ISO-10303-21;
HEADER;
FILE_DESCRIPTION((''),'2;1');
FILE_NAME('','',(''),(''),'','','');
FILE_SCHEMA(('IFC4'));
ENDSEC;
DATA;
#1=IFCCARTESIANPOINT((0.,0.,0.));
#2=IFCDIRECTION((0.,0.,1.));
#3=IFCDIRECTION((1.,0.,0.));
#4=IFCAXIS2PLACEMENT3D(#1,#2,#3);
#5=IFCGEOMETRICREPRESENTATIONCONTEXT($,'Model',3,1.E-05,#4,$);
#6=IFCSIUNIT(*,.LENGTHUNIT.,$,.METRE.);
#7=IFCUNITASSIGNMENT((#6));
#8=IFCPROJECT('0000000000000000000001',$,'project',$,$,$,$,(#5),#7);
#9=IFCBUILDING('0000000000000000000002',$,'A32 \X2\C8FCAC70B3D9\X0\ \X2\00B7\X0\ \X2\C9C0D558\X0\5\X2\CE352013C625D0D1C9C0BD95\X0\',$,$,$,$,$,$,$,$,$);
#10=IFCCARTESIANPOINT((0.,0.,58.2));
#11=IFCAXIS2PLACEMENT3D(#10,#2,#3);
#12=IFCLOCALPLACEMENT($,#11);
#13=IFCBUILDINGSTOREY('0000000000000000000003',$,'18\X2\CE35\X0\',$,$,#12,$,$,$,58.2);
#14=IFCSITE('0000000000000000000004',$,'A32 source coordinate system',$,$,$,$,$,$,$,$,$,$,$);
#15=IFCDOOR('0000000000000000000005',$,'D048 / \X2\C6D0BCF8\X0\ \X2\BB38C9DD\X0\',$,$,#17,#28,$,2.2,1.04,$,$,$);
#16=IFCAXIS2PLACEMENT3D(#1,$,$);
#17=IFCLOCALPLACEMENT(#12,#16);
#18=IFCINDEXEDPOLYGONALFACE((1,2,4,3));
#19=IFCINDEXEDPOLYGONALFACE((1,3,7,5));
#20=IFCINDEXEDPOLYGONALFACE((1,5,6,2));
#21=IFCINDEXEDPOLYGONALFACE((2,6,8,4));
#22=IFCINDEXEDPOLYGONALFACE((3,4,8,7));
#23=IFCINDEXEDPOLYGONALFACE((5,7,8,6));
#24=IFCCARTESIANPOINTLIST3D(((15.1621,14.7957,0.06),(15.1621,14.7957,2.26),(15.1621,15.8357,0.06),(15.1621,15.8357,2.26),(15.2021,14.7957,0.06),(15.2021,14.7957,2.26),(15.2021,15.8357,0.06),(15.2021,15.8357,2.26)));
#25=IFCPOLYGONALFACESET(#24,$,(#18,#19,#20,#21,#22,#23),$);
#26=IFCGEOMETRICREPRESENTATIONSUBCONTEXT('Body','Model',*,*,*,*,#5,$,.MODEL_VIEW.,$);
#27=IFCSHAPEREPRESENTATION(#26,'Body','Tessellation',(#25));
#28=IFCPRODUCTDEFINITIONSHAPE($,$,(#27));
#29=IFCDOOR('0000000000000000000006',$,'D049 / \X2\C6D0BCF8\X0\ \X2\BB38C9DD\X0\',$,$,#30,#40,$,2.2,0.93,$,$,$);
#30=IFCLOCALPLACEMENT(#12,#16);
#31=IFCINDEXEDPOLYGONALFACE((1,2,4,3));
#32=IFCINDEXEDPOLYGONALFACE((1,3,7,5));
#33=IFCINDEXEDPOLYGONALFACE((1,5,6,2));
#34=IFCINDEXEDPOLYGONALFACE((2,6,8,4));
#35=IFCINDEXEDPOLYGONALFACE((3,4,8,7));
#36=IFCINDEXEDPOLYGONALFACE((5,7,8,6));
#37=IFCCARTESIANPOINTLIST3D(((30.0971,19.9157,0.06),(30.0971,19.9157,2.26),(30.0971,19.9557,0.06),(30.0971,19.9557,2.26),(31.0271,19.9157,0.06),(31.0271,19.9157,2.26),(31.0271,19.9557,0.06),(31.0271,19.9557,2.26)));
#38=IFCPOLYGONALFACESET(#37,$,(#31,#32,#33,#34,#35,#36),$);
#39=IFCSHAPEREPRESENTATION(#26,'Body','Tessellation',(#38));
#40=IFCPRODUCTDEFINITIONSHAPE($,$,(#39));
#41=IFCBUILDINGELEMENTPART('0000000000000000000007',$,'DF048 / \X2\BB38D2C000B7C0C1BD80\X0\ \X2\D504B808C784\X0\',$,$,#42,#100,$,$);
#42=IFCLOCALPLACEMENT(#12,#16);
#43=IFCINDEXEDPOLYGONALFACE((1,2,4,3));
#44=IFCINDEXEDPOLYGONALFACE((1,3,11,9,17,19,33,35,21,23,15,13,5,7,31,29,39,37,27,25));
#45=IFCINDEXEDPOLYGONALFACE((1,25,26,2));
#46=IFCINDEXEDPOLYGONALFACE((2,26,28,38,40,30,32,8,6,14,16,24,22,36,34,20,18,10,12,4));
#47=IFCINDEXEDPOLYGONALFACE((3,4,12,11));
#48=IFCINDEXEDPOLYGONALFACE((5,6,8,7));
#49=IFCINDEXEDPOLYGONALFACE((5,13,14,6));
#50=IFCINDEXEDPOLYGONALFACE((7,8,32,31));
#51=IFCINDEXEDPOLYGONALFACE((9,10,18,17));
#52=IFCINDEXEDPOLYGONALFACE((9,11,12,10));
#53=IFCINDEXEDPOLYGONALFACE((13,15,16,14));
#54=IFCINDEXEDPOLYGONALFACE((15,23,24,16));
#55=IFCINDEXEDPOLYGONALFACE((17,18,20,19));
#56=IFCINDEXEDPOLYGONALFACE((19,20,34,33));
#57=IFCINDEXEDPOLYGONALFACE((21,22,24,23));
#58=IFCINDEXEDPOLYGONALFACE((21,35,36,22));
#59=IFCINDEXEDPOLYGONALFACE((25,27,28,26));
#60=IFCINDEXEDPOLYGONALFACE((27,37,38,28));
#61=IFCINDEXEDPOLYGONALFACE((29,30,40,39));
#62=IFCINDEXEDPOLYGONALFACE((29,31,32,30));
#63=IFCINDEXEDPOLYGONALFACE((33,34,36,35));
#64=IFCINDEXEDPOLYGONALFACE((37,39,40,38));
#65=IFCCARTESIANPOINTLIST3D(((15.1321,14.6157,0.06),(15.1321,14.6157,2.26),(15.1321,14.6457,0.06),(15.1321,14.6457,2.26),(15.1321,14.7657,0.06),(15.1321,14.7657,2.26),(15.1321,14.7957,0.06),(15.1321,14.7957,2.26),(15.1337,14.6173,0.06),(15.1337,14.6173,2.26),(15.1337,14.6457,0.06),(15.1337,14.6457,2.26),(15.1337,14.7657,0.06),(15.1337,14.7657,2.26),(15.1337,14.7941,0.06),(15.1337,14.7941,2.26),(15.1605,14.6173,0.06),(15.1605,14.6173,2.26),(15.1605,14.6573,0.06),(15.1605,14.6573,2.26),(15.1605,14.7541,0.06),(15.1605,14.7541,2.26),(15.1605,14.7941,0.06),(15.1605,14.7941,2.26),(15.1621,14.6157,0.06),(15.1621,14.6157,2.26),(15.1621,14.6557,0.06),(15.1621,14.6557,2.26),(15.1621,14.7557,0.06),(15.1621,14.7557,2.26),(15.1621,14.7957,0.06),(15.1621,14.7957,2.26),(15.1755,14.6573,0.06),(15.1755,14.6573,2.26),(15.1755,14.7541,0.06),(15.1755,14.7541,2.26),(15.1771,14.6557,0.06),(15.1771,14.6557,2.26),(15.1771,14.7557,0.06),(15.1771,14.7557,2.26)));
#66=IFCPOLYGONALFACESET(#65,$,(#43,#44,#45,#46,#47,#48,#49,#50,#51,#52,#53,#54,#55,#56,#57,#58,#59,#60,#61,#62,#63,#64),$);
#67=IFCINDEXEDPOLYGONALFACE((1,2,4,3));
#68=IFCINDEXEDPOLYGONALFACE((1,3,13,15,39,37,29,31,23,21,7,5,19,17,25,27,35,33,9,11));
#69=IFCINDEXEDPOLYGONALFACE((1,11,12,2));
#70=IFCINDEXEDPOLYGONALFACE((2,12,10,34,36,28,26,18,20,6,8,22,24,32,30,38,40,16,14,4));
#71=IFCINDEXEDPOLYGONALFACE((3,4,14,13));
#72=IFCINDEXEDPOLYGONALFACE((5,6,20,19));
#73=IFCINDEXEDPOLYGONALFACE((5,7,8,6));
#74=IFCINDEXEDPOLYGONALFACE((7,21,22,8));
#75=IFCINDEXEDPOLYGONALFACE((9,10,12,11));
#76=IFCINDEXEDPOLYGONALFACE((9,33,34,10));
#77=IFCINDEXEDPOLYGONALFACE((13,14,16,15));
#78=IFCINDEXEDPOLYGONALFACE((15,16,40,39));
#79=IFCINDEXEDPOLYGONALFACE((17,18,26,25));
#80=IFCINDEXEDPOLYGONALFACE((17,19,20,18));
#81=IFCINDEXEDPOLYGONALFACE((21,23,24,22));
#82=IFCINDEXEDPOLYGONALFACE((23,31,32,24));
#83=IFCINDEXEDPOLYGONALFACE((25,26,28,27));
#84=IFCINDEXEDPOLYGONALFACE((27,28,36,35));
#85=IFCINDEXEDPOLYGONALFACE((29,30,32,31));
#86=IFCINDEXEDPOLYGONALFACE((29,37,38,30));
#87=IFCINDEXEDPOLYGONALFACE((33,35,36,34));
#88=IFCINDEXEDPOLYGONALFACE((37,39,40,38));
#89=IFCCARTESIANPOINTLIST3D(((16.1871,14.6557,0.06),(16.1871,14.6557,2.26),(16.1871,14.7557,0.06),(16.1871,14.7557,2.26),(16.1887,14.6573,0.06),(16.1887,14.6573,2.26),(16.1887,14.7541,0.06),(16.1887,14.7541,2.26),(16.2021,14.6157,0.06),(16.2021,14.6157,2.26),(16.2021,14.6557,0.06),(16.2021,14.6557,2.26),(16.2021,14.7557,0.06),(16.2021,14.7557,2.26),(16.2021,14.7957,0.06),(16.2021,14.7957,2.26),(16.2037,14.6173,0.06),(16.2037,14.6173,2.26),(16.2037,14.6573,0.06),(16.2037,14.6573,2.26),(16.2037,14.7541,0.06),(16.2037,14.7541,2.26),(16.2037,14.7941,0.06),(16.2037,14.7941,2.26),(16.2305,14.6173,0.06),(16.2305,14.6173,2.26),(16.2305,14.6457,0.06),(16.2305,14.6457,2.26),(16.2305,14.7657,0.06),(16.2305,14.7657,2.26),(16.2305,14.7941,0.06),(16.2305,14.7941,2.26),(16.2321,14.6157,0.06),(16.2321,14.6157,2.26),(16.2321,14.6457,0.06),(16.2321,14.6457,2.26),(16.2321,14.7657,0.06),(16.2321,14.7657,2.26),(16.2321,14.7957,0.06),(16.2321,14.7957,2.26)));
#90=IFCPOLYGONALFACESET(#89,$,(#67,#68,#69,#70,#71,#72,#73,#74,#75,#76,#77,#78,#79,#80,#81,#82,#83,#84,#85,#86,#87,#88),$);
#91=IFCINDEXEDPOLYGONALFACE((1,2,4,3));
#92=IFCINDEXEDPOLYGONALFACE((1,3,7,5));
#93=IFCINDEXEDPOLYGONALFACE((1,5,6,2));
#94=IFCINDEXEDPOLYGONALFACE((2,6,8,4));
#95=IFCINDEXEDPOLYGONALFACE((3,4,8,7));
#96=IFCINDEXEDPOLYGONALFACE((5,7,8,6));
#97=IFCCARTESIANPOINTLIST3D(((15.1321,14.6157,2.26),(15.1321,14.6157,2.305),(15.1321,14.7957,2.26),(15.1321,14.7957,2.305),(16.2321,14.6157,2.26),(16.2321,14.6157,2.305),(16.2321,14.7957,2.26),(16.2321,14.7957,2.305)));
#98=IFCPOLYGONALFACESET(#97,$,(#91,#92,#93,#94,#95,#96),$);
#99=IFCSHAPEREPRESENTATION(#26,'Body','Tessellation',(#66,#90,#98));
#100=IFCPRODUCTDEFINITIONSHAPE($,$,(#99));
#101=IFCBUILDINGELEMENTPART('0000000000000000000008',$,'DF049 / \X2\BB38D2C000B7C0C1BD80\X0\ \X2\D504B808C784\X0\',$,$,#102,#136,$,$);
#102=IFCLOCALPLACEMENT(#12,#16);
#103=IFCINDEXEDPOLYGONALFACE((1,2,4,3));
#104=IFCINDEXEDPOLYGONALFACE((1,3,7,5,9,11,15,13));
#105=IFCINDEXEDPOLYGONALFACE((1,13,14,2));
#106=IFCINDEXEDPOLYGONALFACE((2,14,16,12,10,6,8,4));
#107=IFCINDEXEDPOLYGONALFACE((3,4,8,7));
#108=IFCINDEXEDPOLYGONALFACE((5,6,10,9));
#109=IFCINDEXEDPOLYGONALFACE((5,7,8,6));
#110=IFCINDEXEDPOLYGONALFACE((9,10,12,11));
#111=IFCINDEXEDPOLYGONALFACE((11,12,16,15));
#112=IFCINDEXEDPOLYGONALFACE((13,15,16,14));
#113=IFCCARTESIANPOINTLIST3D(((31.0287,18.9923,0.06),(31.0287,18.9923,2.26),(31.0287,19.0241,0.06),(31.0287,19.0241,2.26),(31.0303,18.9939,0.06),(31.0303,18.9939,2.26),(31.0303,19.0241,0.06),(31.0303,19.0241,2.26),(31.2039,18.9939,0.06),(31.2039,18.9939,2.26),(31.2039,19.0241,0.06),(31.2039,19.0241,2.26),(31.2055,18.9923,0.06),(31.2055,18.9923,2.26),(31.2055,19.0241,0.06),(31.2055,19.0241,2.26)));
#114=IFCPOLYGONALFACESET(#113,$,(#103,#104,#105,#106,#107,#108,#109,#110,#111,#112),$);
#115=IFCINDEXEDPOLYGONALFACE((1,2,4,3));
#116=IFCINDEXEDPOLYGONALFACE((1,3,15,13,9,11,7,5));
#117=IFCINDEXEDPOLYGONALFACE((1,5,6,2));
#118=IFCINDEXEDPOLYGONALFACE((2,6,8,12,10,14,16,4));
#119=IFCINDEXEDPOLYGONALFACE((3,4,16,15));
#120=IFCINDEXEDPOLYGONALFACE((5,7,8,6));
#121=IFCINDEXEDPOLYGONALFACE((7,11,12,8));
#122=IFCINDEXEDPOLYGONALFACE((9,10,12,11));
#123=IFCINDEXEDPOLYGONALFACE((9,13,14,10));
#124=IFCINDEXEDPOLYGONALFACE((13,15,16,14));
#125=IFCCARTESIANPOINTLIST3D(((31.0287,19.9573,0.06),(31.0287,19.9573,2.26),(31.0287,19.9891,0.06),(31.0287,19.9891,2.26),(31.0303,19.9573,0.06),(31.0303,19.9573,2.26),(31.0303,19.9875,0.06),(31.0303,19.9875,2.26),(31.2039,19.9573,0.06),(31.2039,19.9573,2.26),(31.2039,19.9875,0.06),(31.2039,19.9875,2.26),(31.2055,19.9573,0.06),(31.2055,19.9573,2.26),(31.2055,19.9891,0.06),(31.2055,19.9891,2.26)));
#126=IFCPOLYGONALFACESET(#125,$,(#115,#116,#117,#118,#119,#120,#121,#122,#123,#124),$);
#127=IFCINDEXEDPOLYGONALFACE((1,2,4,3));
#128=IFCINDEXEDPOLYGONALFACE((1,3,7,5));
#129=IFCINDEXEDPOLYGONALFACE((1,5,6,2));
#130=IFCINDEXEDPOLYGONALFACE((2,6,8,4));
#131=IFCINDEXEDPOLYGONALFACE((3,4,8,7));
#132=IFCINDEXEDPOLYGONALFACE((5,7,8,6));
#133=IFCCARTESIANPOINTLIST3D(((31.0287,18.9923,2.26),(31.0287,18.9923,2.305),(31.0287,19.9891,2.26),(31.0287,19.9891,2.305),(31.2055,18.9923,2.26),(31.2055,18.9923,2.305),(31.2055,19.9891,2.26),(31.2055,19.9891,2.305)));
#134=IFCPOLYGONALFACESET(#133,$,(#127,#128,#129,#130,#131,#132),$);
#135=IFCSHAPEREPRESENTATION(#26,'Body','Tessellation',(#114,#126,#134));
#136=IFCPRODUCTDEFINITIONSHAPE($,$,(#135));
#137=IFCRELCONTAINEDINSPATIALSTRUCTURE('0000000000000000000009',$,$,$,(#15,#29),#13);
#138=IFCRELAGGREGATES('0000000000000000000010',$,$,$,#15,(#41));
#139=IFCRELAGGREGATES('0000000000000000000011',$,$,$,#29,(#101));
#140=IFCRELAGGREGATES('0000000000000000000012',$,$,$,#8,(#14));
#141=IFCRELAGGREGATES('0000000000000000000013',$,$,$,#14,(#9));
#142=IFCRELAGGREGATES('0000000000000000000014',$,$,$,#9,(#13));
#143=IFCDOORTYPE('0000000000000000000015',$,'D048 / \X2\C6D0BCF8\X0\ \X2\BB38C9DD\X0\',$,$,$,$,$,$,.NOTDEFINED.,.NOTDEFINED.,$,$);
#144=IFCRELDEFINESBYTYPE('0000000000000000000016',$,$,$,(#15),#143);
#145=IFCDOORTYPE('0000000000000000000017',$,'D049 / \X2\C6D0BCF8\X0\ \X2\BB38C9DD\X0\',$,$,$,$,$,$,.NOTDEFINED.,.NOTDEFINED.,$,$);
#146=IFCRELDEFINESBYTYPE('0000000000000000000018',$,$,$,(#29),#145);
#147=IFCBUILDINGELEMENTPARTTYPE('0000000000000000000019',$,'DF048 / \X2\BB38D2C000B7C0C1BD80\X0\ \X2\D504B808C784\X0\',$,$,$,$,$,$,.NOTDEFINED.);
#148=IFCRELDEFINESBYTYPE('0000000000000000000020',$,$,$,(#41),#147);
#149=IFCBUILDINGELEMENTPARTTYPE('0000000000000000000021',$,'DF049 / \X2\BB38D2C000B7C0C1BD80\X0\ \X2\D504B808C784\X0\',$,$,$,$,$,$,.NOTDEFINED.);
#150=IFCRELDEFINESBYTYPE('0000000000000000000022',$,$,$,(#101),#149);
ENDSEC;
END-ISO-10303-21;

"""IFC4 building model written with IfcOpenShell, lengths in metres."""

from ifc_helpers import new_model, si_unit, frame, origin, origin_with_axes, place, context, subcontext, project, spatial, polyline, outline, extrude, source, transform, mapped, type_object, type_shapes, element, aggregate, save


model = new_model("IFC4")

# Units and contexts
model_context = context("Model", 3, precision=1e-05, world=origin_with_axes())
body_context = subcontext(model_context, "Body", "Model", "MODEL_VIEW")
ifc_project = project(units=[si_unit("LENGTHUNIT", "METRE")], contexts=[model_context])

# Site, building, storey
storey_placement = place(None, frame((0.0, 0.0, 58.2), z_axis=(0.0, 0.0, 1.0), x_axis=(1.0, 0.0, 0.0)))
site = spatial("IfcSite", under=ifc_project, Name="A32 source coordinate system")
building = spatial("IfcBuilding", under=site, Name="A32 주거동 · 지하5층–옥탑지붕")
storey = spatial("IfcBuildingStorey", under=building, at=storey_placement, Name="18층", Elevation=58.2)

# Doors
door_type_1 = type_object("IfcDoorType", Name="D048 / 원본 문짝", OperationType="NOTDEFINED", PredefinedType="NOTDEFINED")
shared_shape_1 = source(origin(), body_context, "Body", "SweptSolid", [
    extrude(outline(polyline([(15.2021, 15.8357), (15.2021, 14.7957), (15.1621, 14.7957), (15.1621, 15.8357), (15.2021, 15.8357)])), frame((0.0, 0.0, 0.06)), (0.0, 0.0, 1.0), 2.2),
])
type_shapes(door_type_1, [shared_shape_1])
door_1_placement = place(storey_placement, origin_with_axes())
door_1 = element("IfcDoor", 1, at=door_1_placement, inside=storey, type_object=door_type_1, Name="D048 / 원본 문짝", OverallHeight=2.2, OverallWidth=1.04, context=body_context, shape_type="MappedRepresentation", body=[
    mapped(shared_shape_1, transform((0.0, 0.0, 0.0), scale=1.0)),
])
door_type_2 = type_object("IfcDoorType", Name="D049 / 원본 문짝", OperationType="NOTDEFINED", PredefinedType="NOTDEFINED")
shared_shape_2 = source(origin(), body_context, "Body", "SweptSolid", [
    extrude(outline(polyline([(31.0271, 19.9557), (31.0271, 19.9157), (30.0971, 19.9157), (30.0971, 19.9557), (31.0271, 19.9557)])), frame((0.0, 0.0, 0.06)), (0.0, 0.0, 1.0), 2.2),
])
type_shapes(door_type_2, [shared_shape_2])
door_2_placement = place(storey_placement, origin_with_axes())
door_2 = element("IfcDoor", 2, at=door_2_placement, inside=storey, type_object=door_type_2, Name="D049 / 원본 문짝", OverallHeight=2.2, OverallWidth=0.93, context=body_context, shape_type="MappedRepresentation", body=[
    mapped(shared_shape_2, transform((0.0, 0.0, 0.0), scale=1.0)),
])

# Building element parts
building_element_part_type_1 = type_object("IfcBuildingElementPartType", Name="DF048 / 문틀·상부 프레임", PredefinedType="NOTDEFINED")
shared_shape_3 = source(origin(), body_context, "Body", "SweptSolid", [
    extrude(outline(polyline([(15.1321, 14.7657), (15.1321, 14.7957), (15.1621, 14.7957), (15.1621, 14.7557), (15.1771, 14.7557), (15.1771, 14.6557), (15.1621, 14.6557), (15.1621, 14.6157), (15.1321, 14.6157), (15.1321, 14.6457), (15.1337, 14.6457), (15.1337, 14.6173), (15.1605, 14.6173), (15.1605, 14.6573), (15.1755, 14.6573), (15.1755, 14.7541), (15.1605, 14.7541), (15.1605, 14.7941), (15.1337, 14.7941), (15.1337, 14.7657), (15.1321, 14.7657)])), frame((0.0, 0.0, 0.06)), (0.0, 0.0, 1.0), 2.2),
    extrude(outline(polyline([(16.2305, 14.7941), (16.2037, 14.7941), (16.2037, 14.7541), (16.1887, 14.7541), (16.1887, 14.6573), (16.2037, 14.6573), (16.2037, 14.6173), (16.2305, 14.6173), (16.2305, 14.6457), (16.2321, 14.6457), (16.2321, 14.6157), (16.2021, 14.6157), (16.2021, 14.6557), (16.1871, 14.6557), (16.1871, 14.7557), (16.2021, 14.7557), (16.2021, 14.7957), (16.2321, 14.7957), (16.2321, 14.7657), (16.2305, 14.7657), (16.2305, 14.7941)])), frame((0.0, 0.0, 0.06)), (0.0, 0.0, 1.0), 2.2),
    extrude(outline(polyline([(15.1321, 14.6157), (15.1321, 14.7957), (16.2321, 14.7957), (16.2321, 14.6157), (15.1321, 14.6157)])), frame((0.0, 0.0, 2.26)), (0.0, 0.0, 1.0), 0.045),
])
type_shapes(building_element_part_type_1, [shared_shape_3])
building_element_part_1_placement = place(door_1_placement, origin_with_axes())
building_element_part_1 = element("IfcBuildingElementPart", 3, at=building_element_part_1_placement, type_object=building_element_part_type_1, Name="DF048 / 문틀·상부 프레임", context=body_context, shape_type="MappedRepresentation", body=[
    mapped(shared_shape_3, transform((0.0, 0.0, 0.0), scale=1.0)),
])
aggregate(door_1, [building_element_part_1])
building_element_part_type_2 = type_object("IfcBuildingElementPartType", Name="DF049 / 문틀·상부 프레임", PredefinedType="NOTDEFINED")
shared_shape_4 = source(origin(), body_context, "Body", "SweptSolid", [
    extrude(outline(polyline([(31.0303, 19.0241), (31.0303, 18.9939), (31.2039, 18.9939), (31.2039, 19.0241), (31.2055, 19.0241), (31.2055, 18.9923), (31.0287, 18.9923), (31.0287, 19.0241), (31.0303, 19.0241)])), frame((0.0, 0.0, 0.06)), (0.0, 0.0, 1.0), 2.2),
    extrude(outline(polyline([(31.0287, 19.9891), (31.2055, 19.9891), (31.2055, 19.9573), (31.2039, 19.9573), (31.2039, 19.9875), (31.0303, 19.9875), (31.0303, 19.9573), (31.0287, 19.9573), (31.0287, 19.9891)])), frame((0.0, 0.0, 0.06)), (0.0, 0.0, 1.0), 2.2),
    extrude(outline(polyline([(31.0287, 18.9923), (31.0287, 19.9891), (31.2055, 19.9891), (31.2055, 18.9923), (31.0287, 18.9923)])), frame((0.0, 0.0, 2.26)), (0.0, 0.0, 1.0), 0.045),
])
type_shapes(building_element_part_type_2, [shared_shape_4])
building_element_part_2_placement = place(door_2_placement, origin_with_axes())
building_element_part_2 = element("IfcBuildingElementPart", 4, at=building_element_part_2_placement, type_object=building_element_part_type_2, Name="DF049 / 문틀·상부 프레임", context=body_context, shape_type="MappedRepresentation", body=[
    mapped(shared_shape_4, transform((0.0, 0.0, 0.0), scale=1.0)),
])
aggregate(door_2, [building_element_part_2])

save(model, "model.ifc")
